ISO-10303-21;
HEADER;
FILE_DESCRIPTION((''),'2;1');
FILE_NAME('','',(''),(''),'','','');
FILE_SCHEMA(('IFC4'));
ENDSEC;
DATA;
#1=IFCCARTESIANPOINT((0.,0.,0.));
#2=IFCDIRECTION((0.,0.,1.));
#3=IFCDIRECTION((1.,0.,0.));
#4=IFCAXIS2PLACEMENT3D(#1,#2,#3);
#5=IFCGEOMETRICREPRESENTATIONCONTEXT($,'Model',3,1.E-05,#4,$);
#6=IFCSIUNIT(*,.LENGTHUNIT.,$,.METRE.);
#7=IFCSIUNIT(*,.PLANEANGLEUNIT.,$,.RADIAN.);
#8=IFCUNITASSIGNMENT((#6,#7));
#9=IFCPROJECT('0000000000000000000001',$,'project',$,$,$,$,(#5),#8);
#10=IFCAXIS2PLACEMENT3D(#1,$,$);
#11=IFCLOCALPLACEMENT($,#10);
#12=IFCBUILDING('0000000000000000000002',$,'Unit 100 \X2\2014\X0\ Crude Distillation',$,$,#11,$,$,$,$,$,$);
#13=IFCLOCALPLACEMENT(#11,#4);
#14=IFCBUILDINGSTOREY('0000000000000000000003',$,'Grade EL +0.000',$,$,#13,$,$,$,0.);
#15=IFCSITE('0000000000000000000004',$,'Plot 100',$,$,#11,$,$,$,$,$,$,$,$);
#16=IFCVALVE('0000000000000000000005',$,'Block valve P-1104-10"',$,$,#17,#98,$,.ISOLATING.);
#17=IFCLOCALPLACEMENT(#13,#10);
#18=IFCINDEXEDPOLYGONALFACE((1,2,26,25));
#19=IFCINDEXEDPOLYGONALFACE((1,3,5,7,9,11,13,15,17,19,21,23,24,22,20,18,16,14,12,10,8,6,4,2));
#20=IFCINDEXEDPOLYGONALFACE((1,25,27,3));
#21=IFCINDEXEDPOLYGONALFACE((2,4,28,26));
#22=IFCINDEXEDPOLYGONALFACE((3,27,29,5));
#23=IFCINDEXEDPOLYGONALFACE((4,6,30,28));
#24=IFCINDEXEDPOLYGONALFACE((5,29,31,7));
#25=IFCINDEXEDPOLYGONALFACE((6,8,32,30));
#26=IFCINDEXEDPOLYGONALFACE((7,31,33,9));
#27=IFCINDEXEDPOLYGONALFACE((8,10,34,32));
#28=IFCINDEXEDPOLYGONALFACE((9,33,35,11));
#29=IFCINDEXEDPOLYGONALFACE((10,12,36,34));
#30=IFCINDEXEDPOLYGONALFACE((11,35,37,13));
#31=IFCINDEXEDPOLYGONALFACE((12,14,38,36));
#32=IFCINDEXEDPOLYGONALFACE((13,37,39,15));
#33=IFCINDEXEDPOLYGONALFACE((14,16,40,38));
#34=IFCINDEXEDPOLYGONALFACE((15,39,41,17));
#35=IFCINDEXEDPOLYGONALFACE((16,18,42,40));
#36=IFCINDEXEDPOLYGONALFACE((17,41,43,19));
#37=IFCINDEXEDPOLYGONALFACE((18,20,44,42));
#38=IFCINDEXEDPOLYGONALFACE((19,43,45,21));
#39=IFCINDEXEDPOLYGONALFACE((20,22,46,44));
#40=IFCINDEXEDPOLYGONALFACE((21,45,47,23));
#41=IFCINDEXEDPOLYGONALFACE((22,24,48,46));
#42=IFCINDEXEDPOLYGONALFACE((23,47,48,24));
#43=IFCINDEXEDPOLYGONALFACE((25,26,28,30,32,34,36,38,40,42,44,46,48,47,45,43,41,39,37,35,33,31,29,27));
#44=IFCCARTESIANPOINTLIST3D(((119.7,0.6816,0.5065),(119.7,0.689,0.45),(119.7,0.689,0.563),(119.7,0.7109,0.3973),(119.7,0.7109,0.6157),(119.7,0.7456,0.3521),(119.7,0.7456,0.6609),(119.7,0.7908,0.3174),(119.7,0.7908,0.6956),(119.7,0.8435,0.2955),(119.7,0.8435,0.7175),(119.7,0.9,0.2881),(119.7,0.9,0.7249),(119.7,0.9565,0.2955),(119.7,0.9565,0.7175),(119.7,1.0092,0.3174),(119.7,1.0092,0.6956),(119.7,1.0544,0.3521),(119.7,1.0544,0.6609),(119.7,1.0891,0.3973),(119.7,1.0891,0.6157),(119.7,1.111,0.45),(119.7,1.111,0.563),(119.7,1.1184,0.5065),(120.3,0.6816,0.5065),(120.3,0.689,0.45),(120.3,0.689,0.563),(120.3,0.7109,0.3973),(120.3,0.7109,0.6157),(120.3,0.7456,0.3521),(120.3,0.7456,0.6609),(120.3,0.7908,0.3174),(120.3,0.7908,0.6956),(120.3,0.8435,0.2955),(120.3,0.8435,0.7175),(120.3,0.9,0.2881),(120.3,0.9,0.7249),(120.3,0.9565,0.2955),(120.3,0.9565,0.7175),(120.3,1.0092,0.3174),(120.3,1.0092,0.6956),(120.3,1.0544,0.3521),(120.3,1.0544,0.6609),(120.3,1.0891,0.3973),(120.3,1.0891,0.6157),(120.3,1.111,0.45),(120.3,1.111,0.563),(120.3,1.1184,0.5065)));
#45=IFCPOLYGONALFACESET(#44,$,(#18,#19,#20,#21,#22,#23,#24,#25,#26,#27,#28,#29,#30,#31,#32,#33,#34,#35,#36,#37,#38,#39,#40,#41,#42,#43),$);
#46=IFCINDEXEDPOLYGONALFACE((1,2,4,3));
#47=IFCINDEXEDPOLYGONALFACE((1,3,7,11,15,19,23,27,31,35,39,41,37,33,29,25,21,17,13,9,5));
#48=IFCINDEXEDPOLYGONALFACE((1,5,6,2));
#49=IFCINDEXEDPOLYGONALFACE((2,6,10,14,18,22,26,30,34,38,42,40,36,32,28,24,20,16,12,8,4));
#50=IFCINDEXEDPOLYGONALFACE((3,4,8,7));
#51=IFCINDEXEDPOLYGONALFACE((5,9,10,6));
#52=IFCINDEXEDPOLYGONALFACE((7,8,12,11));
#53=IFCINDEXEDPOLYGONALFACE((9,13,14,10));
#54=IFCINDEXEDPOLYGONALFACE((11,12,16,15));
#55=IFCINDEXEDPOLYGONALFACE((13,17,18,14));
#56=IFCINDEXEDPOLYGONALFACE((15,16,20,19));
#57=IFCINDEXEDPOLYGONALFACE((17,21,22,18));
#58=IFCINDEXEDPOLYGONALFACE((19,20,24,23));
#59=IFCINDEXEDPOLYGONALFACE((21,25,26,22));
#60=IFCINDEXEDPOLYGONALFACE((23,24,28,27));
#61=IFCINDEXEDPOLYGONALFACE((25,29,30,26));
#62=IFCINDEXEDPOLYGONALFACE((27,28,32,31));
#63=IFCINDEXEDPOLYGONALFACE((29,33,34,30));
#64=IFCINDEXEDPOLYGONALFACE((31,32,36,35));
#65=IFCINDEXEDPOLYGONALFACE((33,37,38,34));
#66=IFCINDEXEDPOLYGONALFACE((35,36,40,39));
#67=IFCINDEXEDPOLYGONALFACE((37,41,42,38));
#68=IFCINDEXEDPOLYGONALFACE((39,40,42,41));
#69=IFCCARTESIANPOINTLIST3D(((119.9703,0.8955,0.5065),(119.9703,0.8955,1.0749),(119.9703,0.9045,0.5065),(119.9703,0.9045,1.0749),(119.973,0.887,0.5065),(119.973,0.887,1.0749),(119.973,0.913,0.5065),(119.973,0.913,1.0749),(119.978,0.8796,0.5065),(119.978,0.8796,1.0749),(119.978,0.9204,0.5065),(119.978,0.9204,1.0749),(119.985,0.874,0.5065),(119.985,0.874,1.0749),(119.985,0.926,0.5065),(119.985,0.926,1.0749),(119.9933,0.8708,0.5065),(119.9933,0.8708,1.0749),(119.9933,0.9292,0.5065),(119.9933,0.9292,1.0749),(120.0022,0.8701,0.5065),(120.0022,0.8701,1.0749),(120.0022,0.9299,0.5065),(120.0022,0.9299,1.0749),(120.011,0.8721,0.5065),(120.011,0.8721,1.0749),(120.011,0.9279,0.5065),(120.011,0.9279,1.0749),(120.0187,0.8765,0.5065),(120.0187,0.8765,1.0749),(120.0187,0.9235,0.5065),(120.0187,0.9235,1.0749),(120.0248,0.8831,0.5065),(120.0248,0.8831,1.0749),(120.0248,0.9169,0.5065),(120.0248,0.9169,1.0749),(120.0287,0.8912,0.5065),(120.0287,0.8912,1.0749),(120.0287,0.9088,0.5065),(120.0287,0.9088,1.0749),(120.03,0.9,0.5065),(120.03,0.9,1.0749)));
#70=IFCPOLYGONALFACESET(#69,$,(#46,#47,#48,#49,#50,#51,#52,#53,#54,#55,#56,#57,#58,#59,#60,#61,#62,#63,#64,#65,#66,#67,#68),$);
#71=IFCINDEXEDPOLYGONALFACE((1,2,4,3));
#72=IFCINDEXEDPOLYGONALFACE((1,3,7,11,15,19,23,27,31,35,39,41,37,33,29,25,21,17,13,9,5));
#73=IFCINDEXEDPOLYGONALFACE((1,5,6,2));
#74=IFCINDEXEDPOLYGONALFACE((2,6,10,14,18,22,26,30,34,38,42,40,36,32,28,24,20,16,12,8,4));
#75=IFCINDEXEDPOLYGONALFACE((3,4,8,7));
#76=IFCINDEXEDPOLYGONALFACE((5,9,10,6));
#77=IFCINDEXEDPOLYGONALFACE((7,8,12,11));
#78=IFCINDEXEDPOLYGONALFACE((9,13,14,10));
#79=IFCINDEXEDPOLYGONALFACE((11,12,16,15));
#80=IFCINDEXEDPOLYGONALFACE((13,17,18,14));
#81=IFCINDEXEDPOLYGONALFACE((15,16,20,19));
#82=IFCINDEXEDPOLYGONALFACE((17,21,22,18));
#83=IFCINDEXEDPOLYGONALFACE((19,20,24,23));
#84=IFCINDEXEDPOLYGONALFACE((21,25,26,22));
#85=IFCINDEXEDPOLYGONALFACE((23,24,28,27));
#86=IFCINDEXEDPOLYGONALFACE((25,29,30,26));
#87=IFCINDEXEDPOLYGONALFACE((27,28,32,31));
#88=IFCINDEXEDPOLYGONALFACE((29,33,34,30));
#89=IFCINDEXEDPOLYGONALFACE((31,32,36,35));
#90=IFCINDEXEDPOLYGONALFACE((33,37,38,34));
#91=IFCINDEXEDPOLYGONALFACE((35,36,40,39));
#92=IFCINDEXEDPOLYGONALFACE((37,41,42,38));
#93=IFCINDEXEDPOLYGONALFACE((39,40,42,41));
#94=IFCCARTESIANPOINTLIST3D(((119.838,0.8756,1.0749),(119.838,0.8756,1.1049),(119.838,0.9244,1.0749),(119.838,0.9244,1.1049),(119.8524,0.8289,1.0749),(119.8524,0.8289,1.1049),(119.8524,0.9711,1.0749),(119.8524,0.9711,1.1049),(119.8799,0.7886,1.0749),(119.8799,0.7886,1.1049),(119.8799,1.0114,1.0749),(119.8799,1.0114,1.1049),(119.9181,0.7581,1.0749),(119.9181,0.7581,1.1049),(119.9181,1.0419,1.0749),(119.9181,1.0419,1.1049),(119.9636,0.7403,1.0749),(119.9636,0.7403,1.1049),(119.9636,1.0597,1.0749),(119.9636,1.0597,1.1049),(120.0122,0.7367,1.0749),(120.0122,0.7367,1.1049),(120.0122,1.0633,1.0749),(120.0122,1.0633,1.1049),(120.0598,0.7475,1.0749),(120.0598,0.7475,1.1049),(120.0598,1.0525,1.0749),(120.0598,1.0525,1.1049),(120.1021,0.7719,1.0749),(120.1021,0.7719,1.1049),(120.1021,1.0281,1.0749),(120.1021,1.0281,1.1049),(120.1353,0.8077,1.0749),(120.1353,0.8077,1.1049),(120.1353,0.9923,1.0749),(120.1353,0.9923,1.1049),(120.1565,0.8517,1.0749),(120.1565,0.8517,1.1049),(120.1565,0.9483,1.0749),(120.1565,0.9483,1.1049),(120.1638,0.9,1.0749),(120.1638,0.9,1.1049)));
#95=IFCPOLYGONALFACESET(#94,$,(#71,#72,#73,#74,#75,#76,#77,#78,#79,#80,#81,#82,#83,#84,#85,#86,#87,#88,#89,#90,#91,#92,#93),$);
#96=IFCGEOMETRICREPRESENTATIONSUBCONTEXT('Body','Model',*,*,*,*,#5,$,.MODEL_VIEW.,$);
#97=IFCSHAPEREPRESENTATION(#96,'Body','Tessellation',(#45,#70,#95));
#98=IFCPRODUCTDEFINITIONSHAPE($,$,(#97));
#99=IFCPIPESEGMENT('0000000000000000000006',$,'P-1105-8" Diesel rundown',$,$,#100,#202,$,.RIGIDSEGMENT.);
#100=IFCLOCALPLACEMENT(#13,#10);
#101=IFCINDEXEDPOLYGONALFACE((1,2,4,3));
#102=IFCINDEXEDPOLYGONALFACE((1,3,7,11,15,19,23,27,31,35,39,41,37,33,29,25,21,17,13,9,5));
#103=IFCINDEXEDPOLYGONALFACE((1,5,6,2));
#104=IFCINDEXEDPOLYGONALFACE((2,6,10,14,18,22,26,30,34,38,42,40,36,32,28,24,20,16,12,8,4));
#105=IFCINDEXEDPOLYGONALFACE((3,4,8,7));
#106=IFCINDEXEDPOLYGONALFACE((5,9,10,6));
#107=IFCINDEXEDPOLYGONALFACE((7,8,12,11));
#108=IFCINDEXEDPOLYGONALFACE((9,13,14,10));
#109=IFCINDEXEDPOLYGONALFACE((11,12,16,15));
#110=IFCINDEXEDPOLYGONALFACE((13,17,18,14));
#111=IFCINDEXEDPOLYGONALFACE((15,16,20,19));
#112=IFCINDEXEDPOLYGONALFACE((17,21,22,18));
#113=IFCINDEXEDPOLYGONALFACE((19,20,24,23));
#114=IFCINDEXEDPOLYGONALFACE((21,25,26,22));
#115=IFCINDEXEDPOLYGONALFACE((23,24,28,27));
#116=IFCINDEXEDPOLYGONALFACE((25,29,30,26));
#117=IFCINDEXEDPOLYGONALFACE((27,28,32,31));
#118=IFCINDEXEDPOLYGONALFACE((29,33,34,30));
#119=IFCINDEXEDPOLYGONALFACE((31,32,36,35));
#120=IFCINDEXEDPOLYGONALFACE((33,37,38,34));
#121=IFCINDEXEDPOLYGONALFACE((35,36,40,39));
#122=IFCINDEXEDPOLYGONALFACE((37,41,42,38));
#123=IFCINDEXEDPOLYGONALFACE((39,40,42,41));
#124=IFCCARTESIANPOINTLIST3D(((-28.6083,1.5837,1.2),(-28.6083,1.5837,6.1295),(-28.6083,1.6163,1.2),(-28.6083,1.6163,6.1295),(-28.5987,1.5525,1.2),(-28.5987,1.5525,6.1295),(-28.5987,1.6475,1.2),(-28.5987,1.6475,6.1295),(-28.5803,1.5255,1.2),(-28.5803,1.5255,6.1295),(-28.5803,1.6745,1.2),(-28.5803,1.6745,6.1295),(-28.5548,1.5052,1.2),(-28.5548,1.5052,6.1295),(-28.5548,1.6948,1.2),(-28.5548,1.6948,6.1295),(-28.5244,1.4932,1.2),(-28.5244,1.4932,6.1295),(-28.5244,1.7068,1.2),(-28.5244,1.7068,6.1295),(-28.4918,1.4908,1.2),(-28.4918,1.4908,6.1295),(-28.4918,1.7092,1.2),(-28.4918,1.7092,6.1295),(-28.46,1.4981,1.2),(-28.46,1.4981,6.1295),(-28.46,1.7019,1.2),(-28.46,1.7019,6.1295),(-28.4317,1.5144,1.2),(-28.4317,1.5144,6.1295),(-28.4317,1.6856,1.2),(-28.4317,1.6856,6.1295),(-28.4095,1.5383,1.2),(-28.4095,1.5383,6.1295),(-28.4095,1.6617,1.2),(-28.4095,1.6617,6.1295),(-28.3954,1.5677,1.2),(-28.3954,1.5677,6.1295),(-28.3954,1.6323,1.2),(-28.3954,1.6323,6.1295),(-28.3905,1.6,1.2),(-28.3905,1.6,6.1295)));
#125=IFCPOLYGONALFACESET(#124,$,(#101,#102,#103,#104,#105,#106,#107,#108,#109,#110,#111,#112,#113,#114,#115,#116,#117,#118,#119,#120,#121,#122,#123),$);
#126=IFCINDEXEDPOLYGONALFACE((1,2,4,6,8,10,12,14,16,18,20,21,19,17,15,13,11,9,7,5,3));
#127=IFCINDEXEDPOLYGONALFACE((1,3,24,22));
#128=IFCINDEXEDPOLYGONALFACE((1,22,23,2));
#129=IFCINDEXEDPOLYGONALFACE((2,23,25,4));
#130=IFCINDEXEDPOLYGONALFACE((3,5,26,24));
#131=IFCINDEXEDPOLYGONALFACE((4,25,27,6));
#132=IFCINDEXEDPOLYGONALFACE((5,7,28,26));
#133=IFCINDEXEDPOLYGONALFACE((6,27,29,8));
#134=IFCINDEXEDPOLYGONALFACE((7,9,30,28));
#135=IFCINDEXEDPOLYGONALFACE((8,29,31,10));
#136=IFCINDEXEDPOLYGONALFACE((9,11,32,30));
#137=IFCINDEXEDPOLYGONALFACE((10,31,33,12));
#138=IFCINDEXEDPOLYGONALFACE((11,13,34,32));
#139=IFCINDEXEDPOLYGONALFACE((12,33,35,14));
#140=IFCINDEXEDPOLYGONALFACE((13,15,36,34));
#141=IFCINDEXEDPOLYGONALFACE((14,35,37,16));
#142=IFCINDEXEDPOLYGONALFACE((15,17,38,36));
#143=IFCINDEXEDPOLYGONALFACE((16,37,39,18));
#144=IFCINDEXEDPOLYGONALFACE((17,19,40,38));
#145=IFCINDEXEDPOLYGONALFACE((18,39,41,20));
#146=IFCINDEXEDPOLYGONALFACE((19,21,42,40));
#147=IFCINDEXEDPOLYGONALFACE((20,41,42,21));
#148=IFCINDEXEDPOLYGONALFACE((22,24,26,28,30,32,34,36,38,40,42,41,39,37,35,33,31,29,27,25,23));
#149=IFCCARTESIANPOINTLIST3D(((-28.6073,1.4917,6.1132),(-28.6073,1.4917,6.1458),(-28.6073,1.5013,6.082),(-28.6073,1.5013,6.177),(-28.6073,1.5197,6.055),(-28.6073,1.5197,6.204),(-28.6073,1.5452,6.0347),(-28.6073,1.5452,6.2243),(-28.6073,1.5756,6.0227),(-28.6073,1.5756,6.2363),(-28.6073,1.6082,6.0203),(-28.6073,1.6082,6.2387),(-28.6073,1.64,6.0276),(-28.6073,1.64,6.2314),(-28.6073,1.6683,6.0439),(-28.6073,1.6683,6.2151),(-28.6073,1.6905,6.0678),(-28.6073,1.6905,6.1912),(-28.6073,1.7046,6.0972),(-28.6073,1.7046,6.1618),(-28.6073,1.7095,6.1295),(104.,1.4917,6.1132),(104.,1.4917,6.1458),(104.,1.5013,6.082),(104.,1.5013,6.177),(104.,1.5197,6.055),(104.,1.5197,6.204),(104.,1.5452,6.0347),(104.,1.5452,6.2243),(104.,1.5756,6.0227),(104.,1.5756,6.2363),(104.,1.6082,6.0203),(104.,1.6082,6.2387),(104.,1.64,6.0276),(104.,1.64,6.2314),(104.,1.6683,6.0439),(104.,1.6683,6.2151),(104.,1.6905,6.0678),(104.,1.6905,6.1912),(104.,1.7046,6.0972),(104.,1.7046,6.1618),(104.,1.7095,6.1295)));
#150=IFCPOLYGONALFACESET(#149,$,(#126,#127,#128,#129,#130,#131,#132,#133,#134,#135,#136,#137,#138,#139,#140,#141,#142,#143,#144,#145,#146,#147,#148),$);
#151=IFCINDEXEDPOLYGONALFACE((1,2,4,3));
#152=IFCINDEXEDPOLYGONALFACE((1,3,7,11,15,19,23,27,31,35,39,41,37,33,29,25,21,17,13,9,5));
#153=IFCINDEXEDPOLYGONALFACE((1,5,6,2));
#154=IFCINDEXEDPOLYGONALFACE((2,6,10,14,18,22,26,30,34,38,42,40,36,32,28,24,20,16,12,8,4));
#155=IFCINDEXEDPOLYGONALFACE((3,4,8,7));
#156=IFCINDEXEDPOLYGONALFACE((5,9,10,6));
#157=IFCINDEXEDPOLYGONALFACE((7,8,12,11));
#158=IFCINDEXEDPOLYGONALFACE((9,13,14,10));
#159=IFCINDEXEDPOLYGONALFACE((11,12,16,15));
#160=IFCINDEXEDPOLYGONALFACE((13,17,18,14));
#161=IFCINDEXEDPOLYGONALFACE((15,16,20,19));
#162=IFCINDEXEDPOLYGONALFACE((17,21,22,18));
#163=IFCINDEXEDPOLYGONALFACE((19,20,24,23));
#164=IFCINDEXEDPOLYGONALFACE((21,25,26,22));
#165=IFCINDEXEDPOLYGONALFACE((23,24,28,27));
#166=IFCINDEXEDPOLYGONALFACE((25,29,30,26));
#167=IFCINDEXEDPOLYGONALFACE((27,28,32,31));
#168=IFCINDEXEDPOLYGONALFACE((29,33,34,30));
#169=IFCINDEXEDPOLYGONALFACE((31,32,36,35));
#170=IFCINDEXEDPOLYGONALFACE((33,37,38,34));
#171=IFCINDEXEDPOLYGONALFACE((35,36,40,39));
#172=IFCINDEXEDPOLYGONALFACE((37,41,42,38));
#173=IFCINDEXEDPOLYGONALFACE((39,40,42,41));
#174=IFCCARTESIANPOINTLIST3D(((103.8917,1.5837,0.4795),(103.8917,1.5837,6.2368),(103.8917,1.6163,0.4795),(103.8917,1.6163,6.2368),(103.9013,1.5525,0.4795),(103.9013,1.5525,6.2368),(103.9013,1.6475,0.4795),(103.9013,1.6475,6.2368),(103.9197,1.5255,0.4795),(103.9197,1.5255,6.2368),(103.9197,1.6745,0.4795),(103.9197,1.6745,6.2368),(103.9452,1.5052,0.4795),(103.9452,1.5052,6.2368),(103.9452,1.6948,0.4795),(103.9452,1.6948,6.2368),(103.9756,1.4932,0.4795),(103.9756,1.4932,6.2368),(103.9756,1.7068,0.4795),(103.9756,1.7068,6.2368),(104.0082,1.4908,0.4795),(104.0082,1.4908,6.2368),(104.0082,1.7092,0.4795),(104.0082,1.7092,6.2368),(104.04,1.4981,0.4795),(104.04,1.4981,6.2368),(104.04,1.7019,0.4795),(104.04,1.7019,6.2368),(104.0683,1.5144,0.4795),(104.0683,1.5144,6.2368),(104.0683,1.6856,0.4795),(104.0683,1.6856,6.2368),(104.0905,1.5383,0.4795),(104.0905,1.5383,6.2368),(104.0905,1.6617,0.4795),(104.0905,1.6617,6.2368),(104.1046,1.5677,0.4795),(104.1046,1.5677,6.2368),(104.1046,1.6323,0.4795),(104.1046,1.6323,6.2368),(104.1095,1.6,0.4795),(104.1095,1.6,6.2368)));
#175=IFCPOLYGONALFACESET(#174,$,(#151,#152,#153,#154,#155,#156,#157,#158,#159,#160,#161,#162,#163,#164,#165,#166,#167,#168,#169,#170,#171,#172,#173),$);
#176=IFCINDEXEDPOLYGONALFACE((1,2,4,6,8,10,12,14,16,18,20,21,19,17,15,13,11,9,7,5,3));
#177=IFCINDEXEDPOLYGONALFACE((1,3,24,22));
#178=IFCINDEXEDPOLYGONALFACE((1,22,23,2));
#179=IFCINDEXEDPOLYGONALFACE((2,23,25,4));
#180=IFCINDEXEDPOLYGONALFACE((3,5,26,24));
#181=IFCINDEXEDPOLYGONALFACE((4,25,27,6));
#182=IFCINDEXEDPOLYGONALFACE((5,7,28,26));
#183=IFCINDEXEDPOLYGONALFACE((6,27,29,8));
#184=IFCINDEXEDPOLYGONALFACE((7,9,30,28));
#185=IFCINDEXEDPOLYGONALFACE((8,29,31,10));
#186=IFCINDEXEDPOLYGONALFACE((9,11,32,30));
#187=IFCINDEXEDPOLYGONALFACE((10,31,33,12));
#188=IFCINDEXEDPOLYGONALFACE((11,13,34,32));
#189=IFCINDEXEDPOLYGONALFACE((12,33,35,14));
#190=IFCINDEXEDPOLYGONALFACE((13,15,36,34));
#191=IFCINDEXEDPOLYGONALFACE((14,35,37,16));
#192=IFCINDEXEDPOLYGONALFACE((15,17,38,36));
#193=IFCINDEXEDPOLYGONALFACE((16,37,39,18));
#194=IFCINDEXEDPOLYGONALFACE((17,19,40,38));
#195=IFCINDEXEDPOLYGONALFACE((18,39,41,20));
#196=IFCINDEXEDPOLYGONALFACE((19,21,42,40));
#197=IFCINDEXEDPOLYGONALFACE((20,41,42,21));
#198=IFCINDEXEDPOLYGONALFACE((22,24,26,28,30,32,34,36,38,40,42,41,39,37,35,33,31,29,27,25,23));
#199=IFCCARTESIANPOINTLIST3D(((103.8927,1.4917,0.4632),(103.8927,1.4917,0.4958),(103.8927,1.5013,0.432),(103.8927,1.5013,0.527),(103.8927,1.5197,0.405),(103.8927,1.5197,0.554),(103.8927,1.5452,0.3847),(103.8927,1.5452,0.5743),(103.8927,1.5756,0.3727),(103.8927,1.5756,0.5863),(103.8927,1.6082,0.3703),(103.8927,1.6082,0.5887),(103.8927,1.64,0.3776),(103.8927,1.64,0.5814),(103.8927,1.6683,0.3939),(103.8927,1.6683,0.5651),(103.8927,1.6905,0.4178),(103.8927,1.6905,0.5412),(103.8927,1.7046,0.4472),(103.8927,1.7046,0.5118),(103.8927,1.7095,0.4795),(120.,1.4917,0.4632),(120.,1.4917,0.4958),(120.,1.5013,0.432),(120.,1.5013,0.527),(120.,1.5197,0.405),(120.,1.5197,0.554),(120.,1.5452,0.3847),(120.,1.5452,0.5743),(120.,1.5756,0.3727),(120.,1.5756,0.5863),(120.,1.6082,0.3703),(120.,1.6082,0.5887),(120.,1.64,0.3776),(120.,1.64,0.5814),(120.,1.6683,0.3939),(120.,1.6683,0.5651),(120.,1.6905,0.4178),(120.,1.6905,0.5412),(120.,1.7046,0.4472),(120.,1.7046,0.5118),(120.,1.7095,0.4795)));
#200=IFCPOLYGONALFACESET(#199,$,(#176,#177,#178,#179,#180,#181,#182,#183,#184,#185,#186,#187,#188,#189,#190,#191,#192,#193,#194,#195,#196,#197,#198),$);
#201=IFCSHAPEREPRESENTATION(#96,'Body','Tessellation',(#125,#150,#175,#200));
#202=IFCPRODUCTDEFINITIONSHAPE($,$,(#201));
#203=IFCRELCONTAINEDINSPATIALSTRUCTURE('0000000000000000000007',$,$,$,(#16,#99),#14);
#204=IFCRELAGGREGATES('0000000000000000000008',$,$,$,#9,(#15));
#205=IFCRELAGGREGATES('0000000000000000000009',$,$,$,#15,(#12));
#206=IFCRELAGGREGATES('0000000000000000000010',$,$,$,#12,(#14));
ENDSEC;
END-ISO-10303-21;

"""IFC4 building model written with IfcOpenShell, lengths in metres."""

from ifc_helpers import new_model, si_unit, frame, origin, origin_with_axes, origin_2d, place, context, subcontext, project, spatial, circle, extrude, element, save


model = new_model("IFC4")

# Units and contexts
model_context = context("Model", 3, precision=1e-05, world=origin_with_axes())
body_context = subcontext(model_context, "Body", "Model", "MODEL_VIEW")
ifc_project = project(units=[si_unit("LENGTHUNIT", "METRE"), si_unit("PLANEANGLEUNIT", "RADIAN")], contexts=[model_context])

# Site, building, storey
placement = place(None, origin())
site = spatial("IfcSite", under=ifc_project, at=placement, Name="Plot 100")
building = spatial("IfcBuilding", under=site, at=placement, Name="Unit 100 — Crude Distillation")
storey_placement = place(placement, origin_with_axes())
storey = spatial("IfcBuildingStorey", under=building, at=storey_placement, Name="Grade EL +0.000", Elevation=0.0)

# Valve
valve_1_placement = place(storey_placement, origin_with_axes())
element("IfcValve", 1, at=valve_1_placement, inside=storey, Name="Block valve P-1104-10\"", PredefinedType="ISOLATING", context=body_context, shape_type="SweptSolid", body=[
    extrude(circle(Radius=0.2184, at=origin_2d()), frame((119.7, 0.9, 0.5065), z_axis=(1.0, 0.0, 0.0), x_axis=(0.0, 1.0, 0.0)), (0.0, 0.0, 1.0), 0.6),
    extrude(circle(Radius=0.03, at=origin_2d()), frame((120.0, 0.9, 0.5065), z_axis=(0.0, 0.0, 1.0), x_axis=(1.0, 0.0, 0.0)), (0.0, 0.0, 1.0), 0.5684),
    extrude(circle(Radius=0.1638, at=origin_2d()), frame((120.0, 0.9, 1.0749), z_axis=(0.0, 0.0, 1.0), x_axis=(1.0, 0.0, 0.0)), (0.0, 0.0, 1.0), 0.03),
])

# Pipe segment
pipe_segment_1_placement = place(storey_placement, origin_with_axes())
element("IfcPipeSegment", 2, at=pipe_segment_1_placement, inside=storey, Name="P-1105-8\" Diesel rundown", PredefinedType="RIGIDSEGMENT", context=body_context, shape_type="SweptSolid", body=[
    extrude(circle(Radius=0.1095, at=origin_2d()), frame((-28.5, 1.6, 1.2), z_axis=(0.0, 0.0, 1.0), x_axis=(1.0, 0.0, 0.0)), (0.0, 0.0, 1.0), 4.9295),
    extrude(circle(Radius=0.1095, at=origin_2d()), frame((-28.6073, 1.6, 6.1295), z_axis=(1.0, 0.0, 0.0), x_axis=(0.0, 1.0, 0.0)), (0.0, 0.0, 1.0), 132.6073),
    extrude(circle(Radius=0.1095, at=origin_2d()), frame((104.0, 1.6, 6.2368), z_axis=(0.0, 0.0, -1.0), x_axis=(1.0, 0.0, 0.0)), (0.0, 0.0, 1.0), 5.7573),
    extrude(circle(Radius=0.1095, at=origin_2d()), frame((103.8927, 1.6, 0.4795), z_axis=(1.0, 0.0, 0.0), x_axis=(0.0, 1.0, 0.0)), (0.0, 0.0, 1.0), 16.1073),
])

save(model, "model.ifc")
